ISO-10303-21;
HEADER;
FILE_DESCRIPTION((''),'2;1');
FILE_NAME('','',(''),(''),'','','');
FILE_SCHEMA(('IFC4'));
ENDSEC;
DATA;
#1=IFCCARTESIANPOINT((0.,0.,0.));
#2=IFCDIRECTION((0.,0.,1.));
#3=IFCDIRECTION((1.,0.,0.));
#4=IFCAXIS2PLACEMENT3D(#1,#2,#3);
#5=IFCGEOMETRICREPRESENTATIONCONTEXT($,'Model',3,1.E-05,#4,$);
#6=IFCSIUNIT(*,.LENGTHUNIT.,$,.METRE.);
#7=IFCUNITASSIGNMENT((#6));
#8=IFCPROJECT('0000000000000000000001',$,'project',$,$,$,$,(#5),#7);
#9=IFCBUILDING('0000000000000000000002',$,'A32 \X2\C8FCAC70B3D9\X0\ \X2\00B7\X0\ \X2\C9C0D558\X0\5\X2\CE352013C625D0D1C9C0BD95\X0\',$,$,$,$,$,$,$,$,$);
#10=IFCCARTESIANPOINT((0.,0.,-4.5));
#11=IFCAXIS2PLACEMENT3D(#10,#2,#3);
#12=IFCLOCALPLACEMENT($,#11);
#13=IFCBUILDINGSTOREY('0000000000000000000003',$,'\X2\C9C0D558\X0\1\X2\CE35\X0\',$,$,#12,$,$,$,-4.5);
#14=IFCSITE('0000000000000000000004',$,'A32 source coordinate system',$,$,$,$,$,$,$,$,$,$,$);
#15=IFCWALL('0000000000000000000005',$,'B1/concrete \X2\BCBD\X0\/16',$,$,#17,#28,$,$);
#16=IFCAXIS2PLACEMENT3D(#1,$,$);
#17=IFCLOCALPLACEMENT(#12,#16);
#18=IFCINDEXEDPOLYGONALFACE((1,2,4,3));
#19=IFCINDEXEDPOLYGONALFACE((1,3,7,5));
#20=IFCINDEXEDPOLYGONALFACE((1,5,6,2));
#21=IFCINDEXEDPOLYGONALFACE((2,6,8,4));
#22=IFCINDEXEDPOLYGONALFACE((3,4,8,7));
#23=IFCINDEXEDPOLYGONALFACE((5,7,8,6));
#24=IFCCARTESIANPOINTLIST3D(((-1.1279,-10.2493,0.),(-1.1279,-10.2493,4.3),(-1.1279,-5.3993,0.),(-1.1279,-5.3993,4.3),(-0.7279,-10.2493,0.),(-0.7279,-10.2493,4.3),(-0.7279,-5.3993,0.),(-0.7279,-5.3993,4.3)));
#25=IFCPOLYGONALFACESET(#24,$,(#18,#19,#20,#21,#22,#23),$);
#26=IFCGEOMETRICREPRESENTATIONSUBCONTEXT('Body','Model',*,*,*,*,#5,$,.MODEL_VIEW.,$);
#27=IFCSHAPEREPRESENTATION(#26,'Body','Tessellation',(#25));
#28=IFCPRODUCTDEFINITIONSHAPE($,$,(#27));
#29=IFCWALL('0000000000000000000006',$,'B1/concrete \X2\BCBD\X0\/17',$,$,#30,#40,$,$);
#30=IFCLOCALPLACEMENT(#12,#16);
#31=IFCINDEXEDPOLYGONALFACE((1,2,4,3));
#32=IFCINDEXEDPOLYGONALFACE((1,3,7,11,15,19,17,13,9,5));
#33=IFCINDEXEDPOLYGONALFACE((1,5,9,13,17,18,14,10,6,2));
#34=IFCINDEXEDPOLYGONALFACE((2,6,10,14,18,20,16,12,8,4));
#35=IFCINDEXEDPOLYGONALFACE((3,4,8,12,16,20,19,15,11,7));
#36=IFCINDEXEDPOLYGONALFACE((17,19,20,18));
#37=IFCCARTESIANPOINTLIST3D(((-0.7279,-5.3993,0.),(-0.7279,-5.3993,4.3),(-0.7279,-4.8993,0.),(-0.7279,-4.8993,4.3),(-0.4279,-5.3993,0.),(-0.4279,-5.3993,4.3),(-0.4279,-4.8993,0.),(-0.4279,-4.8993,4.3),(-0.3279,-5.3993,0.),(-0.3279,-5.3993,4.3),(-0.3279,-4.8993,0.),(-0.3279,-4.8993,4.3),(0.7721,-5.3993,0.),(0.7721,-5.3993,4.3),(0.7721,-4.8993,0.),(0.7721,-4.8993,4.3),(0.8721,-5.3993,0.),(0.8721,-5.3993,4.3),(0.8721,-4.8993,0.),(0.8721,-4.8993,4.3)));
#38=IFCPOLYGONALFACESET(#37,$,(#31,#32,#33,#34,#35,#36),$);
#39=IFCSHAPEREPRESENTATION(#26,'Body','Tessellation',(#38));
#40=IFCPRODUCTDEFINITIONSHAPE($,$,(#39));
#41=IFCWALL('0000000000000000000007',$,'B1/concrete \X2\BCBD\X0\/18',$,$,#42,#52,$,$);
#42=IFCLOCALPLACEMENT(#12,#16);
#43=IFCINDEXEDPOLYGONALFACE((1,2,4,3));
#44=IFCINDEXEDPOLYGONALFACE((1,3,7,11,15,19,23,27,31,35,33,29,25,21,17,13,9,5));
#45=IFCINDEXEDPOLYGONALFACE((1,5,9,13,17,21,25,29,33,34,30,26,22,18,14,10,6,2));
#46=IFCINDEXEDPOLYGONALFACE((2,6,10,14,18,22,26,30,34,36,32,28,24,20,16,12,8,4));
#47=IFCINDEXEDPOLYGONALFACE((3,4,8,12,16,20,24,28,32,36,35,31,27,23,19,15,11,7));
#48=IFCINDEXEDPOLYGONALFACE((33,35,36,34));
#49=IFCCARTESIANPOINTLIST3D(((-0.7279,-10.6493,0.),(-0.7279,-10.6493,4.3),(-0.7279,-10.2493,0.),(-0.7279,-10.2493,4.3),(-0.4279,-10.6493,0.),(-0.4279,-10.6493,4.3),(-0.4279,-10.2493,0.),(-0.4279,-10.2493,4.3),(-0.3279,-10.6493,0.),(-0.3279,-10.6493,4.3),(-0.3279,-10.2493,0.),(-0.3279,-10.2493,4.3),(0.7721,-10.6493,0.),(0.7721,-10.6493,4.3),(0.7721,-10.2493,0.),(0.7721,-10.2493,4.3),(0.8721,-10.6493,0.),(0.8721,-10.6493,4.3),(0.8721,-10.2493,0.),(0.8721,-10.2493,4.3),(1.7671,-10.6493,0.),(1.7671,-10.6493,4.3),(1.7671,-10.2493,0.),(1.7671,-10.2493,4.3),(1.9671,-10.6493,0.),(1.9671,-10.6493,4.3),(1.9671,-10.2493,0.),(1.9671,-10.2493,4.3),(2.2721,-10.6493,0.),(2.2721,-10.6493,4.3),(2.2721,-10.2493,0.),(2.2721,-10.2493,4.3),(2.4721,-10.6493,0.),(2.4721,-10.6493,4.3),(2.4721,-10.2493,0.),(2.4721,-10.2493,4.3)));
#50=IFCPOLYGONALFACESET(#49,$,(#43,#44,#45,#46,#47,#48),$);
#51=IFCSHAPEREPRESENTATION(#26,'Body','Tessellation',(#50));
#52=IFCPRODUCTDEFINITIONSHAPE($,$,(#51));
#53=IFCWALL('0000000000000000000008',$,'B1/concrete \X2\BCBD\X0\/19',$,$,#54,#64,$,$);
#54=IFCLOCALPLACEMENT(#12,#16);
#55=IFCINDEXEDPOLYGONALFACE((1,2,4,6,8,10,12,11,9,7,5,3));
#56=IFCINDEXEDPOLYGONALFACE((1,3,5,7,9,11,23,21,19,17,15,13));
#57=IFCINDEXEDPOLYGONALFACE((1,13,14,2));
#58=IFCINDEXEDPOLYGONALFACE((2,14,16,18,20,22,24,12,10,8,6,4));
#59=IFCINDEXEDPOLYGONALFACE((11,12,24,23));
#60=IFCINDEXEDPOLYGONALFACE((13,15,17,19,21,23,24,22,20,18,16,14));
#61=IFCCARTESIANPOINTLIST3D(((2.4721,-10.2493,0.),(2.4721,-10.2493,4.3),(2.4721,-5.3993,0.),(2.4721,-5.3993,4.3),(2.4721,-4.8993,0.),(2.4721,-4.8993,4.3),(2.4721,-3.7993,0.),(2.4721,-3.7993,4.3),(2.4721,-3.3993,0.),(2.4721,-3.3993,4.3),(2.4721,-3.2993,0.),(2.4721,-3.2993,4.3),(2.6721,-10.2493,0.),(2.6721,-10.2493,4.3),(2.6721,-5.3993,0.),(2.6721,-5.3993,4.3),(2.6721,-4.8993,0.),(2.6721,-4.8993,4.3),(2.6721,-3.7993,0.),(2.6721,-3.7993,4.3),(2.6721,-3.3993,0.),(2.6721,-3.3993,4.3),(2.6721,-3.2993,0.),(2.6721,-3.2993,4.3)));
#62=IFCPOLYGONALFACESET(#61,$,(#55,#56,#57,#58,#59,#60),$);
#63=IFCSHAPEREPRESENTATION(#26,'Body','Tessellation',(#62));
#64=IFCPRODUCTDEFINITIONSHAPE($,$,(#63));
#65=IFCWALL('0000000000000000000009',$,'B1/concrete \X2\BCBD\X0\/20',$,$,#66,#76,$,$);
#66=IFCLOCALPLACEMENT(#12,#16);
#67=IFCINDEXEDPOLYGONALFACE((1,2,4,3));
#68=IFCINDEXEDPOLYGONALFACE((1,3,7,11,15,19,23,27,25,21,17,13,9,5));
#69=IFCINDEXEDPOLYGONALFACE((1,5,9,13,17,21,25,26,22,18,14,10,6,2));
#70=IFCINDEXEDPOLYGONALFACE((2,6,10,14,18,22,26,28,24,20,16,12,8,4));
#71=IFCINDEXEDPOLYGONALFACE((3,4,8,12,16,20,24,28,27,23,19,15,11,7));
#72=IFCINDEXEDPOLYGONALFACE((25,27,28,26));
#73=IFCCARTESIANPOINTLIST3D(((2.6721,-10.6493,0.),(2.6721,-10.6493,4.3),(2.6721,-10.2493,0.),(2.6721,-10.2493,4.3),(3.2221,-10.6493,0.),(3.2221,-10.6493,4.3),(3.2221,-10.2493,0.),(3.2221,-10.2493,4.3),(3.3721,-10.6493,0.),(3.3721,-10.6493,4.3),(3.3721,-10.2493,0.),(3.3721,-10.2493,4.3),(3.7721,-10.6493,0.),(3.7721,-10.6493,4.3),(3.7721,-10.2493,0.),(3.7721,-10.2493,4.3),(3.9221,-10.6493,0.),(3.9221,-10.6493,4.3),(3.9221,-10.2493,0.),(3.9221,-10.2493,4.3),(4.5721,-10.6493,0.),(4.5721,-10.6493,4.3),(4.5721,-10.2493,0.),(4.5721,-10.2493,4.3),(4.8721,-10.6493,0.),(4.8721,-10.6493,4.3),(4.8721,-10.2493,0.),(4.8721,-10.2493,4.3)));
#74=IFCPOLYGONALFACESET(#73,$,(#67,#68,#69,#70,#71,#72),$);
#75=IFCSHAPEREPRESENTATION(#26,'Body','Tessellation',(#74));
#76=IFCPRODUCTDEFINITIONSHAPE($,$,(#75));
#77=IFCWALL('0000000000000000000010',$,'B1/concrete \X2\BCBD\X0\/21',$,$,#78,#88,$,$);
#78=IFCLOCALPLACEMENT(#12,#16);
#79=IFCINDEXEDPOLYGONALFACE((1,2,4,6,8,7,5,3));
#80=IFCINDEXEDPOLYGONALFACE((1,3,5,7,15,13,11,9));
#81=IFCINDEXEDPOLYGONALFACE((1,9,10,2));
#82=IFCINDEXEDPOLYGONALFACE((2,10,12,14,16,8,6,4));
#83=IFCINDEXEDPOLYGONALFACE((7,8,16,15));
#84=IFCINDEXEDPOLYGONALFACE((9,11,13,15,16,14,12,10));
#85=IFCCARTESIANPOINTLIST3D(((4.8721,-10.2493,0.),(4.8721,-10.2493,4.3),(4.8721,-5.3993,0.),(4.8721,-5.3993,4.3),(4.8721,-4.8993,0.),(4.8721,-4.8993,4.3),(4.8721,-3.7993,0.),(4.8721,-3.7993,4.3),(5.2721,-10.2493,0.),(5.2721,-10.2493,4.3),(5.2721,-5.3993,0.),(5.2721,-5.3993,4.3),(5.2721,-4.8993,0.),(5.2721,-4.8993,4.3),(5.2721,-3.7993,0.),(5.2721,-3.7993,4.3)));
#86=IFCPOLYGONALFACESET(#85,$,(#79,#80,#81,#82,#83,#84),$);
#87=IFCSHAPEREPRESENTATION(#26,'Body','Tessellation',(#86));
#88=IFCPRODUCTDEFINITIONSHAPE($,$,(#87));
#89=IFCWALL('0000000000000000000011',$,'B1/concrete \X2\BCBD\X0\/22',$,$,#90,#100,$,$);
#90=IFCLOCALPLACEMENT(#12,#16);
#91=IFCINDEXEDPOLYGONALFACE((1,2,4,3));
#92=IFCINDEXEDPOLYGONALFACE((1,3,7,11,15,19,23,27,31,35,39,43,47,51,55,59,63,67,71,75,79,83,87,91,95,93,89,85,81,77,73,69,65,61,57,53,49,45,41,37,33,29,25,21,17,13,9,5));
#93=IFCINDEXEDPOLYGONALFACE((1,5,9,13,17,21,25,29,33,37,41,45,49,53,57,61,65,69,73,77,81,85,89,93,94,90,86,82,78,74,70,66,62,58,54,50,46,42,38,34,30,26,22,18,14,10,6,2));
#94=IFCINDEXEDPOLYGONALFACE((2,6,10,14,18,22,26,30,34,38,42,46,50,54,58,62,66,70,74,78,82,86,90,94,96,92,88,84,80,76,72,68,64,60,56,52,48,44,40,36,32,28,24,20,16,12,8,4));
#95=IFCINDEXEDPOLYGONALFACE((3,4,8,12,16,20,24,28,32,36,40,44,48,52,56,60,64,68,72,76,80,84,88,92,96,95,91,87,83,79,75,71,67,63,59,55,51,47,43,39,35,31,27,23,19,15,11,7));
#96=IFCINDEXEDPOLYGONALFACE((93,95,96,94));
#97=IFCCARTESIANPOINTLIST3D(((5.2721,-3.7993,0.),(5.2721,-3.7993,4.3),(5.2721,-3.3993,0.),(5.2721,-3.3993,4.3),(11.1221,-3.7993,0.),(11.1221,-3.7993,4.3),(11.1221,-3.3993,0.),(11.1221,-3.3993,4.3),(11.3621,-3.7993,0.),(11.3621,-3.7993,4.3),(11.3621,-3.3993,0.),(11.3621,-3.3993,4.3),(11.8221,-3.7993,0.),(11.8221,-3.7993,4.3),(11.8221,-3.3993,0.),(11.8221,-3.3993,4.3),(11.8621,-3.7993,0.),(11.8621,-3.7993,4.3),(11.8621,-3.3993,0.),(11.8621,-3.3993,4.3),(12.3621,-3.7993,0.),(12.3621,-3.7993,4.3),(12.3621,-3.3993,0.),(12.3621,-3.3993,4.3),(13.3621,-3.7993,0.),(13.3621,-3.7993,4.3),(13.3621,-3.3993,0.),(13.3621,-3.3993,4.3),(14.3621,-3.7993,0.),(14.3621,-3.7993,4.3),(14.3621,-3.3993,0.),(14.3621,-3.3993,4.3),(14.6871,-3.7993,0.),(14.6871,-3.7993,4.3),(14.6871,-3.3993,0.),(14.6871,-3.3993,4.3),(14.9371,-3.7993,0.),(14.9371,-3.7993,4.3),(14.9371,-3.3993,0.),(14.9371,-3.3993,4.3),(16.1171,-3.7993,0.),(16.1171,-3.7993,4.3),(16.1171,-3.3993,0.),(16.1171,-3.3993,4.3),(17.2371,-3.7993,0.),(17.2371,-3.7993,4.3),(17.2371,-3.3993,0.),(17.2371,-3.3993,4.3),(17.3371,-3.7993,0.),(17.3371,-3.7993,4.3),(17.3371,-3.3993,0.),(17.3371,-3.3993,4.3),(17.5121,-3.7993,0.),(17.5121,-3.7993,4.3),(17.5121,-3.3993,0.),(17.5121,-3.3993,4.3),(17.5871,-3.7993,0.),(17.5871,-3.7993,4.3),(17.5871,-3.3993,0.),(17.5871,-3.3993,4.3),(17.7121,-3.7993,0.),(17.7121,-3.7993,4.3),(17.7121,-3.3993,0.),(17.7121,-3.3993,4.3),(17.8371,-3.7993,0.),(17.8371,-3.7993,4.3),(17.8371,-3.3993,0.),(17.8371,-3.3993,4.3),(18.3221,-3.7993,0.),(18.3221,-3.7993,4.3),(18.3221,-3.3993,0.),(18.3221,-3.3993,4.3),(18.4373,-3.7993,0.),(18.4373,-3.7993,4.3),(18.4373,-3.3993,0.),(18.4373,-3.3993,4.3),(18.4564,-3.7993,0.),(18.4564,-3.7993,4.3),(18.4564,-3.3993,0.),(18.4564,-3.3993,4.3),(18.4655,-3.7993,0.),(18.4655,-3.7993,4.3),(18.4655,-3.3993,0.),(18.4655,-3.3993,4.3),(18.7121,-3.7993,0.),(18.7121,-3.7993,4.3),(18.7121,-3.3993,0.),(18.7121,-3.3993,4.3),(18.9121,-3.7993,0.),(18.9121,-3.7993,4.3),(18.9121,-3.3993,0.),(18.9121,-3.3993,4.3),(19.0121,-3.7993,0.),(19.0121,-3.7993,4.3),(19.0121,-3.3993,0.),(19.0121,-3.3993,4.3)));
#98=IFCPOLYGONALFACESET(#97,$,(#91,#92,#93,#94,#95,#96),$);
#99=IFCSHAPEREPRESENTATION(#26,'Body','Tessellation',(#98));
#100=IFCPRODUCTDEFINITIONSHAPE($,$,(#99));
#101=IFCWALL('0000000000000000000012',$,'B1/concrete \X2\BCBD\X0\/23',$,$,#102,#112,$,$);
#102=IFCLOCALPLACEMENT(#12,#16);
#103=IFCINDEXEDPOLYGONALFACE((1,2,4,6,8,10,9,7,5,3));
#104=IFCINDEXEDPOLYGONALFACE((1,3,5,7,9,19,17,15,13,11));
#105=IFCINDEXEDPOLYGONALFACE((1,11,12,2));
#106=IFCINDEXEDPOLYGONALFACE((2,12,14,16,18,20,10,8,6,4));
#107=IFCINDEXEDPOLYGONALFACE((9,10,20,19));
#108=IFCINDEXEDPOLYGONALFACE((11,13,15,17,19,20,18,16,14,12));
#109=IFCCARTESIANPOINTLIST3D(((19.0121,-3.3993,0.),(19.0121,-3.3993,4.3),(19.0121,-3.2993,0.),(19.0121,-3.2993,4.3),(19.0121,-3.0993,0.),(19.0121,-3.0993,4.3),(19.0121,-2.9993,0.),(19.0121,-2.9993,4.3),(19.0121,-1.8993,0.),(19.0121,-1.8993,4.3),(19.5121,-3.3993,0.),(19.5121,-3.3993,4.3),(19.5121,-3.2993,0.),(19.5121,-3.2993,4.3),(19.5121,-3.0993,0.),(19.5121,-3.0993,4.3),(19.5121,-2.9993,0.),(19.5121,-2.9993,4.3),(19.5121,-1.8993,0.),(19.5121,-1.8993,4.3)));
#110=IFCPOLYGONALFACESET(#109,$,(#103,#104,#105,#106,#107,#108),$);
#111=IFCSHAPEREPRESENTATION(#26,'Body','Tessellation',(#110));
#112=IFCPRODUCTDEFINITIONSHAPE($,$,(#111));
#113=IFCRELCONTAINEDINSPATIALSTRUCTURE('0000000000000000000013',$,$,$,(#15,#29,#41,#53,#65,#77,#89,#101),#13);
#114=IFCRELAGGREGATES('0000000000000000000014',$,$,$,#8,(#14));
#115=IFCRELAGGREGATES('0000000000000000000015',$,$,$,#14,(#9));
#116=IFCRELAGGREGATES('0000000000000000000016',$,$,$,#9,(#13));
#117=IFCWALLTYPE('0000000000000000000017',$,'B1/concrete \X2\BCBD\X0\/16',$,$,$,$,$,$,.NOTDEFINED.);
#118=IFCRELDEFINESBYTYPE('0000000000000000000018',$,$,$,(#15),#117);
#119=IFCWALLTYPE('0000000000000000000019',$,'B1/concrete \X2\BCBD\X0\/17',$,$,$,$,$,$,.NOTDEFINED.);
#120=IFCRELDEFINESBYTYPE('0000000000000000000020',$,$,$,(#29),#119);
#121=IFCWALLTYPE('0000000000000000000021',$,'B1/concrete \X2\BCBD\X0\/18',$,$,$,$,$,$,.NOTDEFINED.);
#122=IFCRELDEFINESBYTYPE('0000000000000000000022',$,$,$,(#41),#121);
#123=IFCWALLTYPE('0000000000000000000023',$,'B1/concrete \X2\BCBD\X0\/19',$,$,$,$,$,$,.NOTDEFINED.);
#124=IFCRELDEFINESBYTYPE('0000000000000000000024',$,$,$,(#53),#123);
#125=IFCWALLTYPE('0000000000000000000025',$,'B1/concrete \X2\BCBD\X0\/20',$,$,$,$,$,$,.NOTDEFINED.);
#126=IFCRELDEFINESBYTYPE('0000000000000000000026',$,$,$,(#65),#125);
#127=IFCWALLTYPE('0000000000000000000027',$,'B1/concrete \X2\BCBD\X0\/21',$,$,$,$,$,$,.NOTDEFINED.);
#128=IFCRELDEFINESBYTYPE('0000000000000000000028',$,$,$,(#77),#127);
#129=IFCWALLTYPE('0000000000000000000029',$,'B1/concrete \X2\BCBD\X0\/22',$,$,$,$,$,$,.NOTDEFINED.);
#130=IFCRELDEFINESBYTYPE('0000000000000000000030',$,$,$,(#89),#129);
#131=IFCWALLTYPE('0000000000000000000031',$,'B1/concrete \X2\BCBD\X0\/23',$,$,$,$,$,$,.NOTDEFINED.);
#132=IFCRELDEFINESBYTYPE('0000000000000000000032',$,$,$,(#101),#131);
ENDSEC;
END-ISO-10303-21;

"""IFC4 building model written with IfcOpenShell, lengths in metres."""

from ifc_helpers import new_model, si_unit, frame, origin, origin_with_axes, place, context, subcontext, project, spatial, polyline, outline, extrude, source, transform, mapped, type_object, type_shapes, element, save


model = new_model("IFC4")

# Units and contexts
model_context = context("Model", 3, precision=1e-05, world=origin_with_axes())
body_context = subcontext(model_context, "Body", "Model", "MODEL_VIEW")
ifc_project = project(units=[si_unit("LENGTHUNIT", "METRE")], contexts=[model_context])

# Site, building, storey
site = spatial("IfcSite", under=ifc_project, Name="A32 source coordinate system")
building = spatial("IfcBuilding", under=site, Name="A32 주거동 · 지하5층–옥탑지붕")
storey_placement = place(None, frame((0.0, 0.0, -4.5), z_axis=(0.0, 0.0, 1.0), x_axis=(1.0, 0.0, 0.0)))
storey = spatial("IfcBuildingStorey", under=building, at=storey_placement, Name="지하1층", Elevation=-4.5)

# Walls
wall_type_1 = type_object("IfcWallType", Name="B1/concrete 벽/16", PredefinedType="NOTDEFINED")
shared_shape_1 = source(origin(), body_context, "Body", "SweptSolid", [
    extrude(outline(polyline([(-0.7279, -10.2493), (-1.1279, -10.2493), (-1.1279, -5.3993), (-0.7279, -5.3993), (-0.7279, -10.2493)])), origin(), (0.0, 0.0, 1.0), 4.3),
])
type_shapes(wall_type_1, [shared_shape_1])
wall_1_placement = place(storey_placement, origin_with_axes())
element("IfcWall", 1, at=wall_1_placement, inside=storey, type_object=wall_type_1, Name="B1/concrete 벽/16", context=body_context, shape_type="MappedRepresentation", body=[
    mapped(shared_shape_1, transform((0.0, 0.0, 0.0), scale=1.0)),
])
wall_type_2 = type_object("IfcWallType", Name="B1/concrete 벽/17", PredefinedType="NOTDEFINED")
shared_shape_2 = source(origin(), body_context, "Body", "SweptSolid", [
    extrude(outline(polyline([(-0.3279, -4.8993), (0.7721, -4.8993), (0.8721, -4.8993), (0.8721, -5.3993), (0.7721, -5.3993), (-0.3279, -5.3993), (-0.4279, -5.3993), (-0.7279, -5.3993), (-0.7279, -4.8993), (-0.4279, -4.8993), (-0.3279, -4.8993)])), origin(), (0.0, 0.0, 1.0), 4.3),
])
type_shapes(wall_type_2, [shared_shape_2])
wall_2_placement = place(storey_placement, origin_with_axes())
element("IfcWall", 2, at=wall_2_placement, inside=storey, type_object=wall_type_2, Name="B1/concrete 벽/17", context=body_context, shape_type="MappedRepresentation", body=[
    mapped(shared_shape_2, transform((0.0, 0.0, 0.0), scale=1.0)),
])
wall_type_3 = type_object("IfcWallType", Name="B1/concrete 벽/18", PredefinedType="NOTDEFINED")
shared_shape_3 = source(origin(), body_context, "Body", "SweptSolid", [
    extrude(outline(polyline([(0.7721, -10.2493), (0.8721, -10.2493), (1.7671, -10.2493), (1.9671, -10.2493), (2.2721, -10.2493), (2.4721, -10.2493), (2.4721, -10.6493), (2.2721, -10.6493), (1.9671, -10.6493), (1.7671, -10.6493), (0.8721, -10.6493), (0.7721, -10.6493), (-0.3279, -10.6493), (-0.4279, -10.6493), (-0.7279, -10.6493), (-0.7279, -10.2493), (-0.4279, -10.2493), (-0.3279, -10.2493), (0.7721, -10.2493)])), origin(), (0.0, 0.0, 1.0), 4.3),
])
type_shapes(wall_type_3, [shared_shape_3])
wall_3_placement = place(storey_placement, origin_with_axes())
element("IfcWall", 3, at=wall_3_placement, inside=storey, type_object=wall_type_3, Name="B1/concrete 벽/18", context=body_context, shape_type="MappedRepresentation", body=[
    mapped(shared_shape_3, transform((0.0, 0.0, 0.0), scale=1.0)),
])
wall_type_4 = type_object("IfcWallType", Name="B1/concrete 벽/19", PredefinedType="NOTDEFINED")
shared_shape_4 = source(origin(), body_context, "Body", "SweptSolid", [
    extrude(outline(polyline([(2.4721, -3.7993), (2.4721, -3.3993), (2.4721, -3.2993), (2.6721, -3.2993), (2.6721, -3.3993), (2.6721, -3.7993), (2.6721, -4.8993), (2.6721, -5.3993), (2.6721, -10.2493), (2.4721, -10.2493), (2.4721, -5.3993), (2.4721, -4.8993), (2.4721, -3.7993)])), origin(), (0.0, 0.0, 1.0), 4.3),
])
type_shapes(wall_type_4, [shared_shape_4])
wall_4_placement = place(storey_placement, origin_with_axes())
element("IfcWall", 4, at=wall_4_placement, inside=storey, type_object=wall_type_4, Name="B1/concrete 벽/19", context=body_context, shape_type="MappedRepresentation", body=[
    mapped(shared_shape_4, transform((0.0, 0.0, 0.0), scale=1.0)),
])
wall_type_5 = type_object("IfcWallType", Name="B1/concrete 벽/20", PredefinedType="NOTDEFINED")
shared_shape_5 = source(origin(), body_context, "Body", "SweptSolid", [
    extrude(outline(polyline([(3.7721, -10.2493), (3.9221, -10.2493), (4.5721, -10.2493), (4.8721, -10.2493), (4.8721, -10.6493), (4.5721, -10.6493), (3.9221, -10.6493), (3.7721, -10.6493), (3.3721, -10.6493), (3.2221, -10.6493), (2.6721, -10.6493), (2.6721, -10.2493), (3.2221, -10.2493), (3.3721, -10.2493), (3.7721, -10.2493)])), origin(), (0.0, 0.0, 1.0), 4.3),
])
type_shapes(wall_type_5, [shared_shape_5])
wall_5_placement = place(storey_placement, origin_with_axes())
element("IfcWall", 5, at=wall_5_placement, inside=storey, type_object=wall_type_5, Name="B1/concrete 벽/20", context=body_context, shape_type="MappedRepresentation", body=[
    mapped(shared_shape_5, transform((0.0, 0.0, 0.0), scale=1.0)),
])
wall_type_6 = type_object("IfcWallType", Name="B1/concrete 벽/21", PredefinedType="NOTDEFINED")
shared_shape_6 = source(origin(), body_context, "Body", "SweptSolid", [
    extrude(outline(polyline([(4.8721, -3.7993), (5.2721, -3.7993), (5.2721, -4.8993), (5.2721, -5.3993), (5.2721, -10.2493), (4.8721, -10.2493), (4.8721, -5.3993), (4.8721, -4.8993), (4.8721, -3.7993)])), origin(), (0.0, 0.0, 1.0), 4.3),
])
type_shapes(wall_type_6, [shared_shape_6])
wall_6_placement = place(storey_placement, origin_with_axes())
element("IfcWall", 6, at=wall_6_placement, inside=storey, type_object=wall_type_6, Name="B1/concrete 벽/21", context=body_context, shape_type="MappedRepresentation", body=[
    mapped(shared_shape_6, transform((0.0, 0.0, 0.0), scale=1.0)),
])
wall_type_7 = type_object("IfcWallType", Name="B1/concrete 벽/22", PredefinedType="NOTDEFINED")
shared_shape_7 = source(origin(), body_context, "Body", "SweptSolid", [
    extrude(outline(polyline([(11.3621, -3.3993), (11.8221, -3.3993), (11.8621, -3.3993), (12.3621, -3.3993), (13.3621, -3.3993), (14.3621, -3.3993), (14.6871, -3.3993), (14.9371, -3.3993), (16.1171, -3.3993), (17.2371, -3.3993), (17.3371, -3.3993), (17.5121, -3.3993), (17.5871, -3.3993), (17.7121, -3.3993), (17.8371, -3.3993), (18.3221, -3.3993), (18.4373, -3.3993), (18.4564, -3.3993), (18.4655, -3.3993), (18.7121, -3.3993), (18.9121, -3.3993), (19.0121, -3.3993), (19.0121, -3.7993), (18.9121, -3.7993), (18.7121, -3.7993), (18.4655, -3.7993), (18.4564, -3.7993), (18.4373, -3.7993), (18.3221, -3.7993), (17.8371, -3.7993), (17.7121, -3.7993), (17.5871, -3.7993), (17.5121, -3.7993), (17.3371, -3.7993), (17.2371, -3.7993), (16.1171, -3.7993), (14.9371, -3.7993), (14.6871, -3.7993), (14.3621, -3.7993), (13.3621, -3.7993), (12.3621, -3.7993), (11.8621, -3.7993), (11.8221, -3.7993), (11.3621, -3.7993), (11.1221, -3.7993), (5.2721, -3.7993), (5.2721, -3.3993), (11.1221, -3.3993), (11.3621, -3.3993)])), origin(), (0.0, 0.0, 1.0), 4.3),
])
type_shapes(wall_type_7, [shared_shape_7])
wall_7_placement = place(storey_placement, origin_with_axes())
element("IfcWall", 7, at=wall_7_placement, inside=storey, type_object=wall_type_7, Name="B1/concrete 벽/22", context=body_context, shape_type="MappedRepresentation", body=[
    mapped(shared_shape_7, transform((0.0, 0.0, 0.0), scale=1.0)),
])
wall_type_8 = type_object("IfcWallType", Name="B1/concrete 벽/23", PredefinedType="NOTDEFINED")
shared_shape_8 = source(origin(), body_context, "Body", "SweptSolid", [
    extrude(outline(polyline([(19.0121, -2.9993), (19.0121, -1.8993), (19.5121, -1.8993), (19.5121, -2.9993), (19.5121, -3.0993), (19.5121, -3.2993), (19.5121, -3.3993), (19.0121, -3.3993), (19.0121, -3.2993), (19.0121, -3.0993), (19.0121, -2.9993)])), origin(), (0.0, 0.0, 1.0), 4.3),
])
type_shapes(wall_type_8, [shared_shape_8])
wall_8_placement = place(storey_placement, origin_with_axes())
element("IfcWall", 8, at=wall_8_placement, inside=storey, type_object=wall_type_8, Name="B1/concrete 벽/23", context=body_context, shape_type="MappedRepresentation", body=[
    mapped(shared_shape_8, transform((0.0, 0.0, 0.0), scale=1.0)),
])

save(model, "model.ifc")
